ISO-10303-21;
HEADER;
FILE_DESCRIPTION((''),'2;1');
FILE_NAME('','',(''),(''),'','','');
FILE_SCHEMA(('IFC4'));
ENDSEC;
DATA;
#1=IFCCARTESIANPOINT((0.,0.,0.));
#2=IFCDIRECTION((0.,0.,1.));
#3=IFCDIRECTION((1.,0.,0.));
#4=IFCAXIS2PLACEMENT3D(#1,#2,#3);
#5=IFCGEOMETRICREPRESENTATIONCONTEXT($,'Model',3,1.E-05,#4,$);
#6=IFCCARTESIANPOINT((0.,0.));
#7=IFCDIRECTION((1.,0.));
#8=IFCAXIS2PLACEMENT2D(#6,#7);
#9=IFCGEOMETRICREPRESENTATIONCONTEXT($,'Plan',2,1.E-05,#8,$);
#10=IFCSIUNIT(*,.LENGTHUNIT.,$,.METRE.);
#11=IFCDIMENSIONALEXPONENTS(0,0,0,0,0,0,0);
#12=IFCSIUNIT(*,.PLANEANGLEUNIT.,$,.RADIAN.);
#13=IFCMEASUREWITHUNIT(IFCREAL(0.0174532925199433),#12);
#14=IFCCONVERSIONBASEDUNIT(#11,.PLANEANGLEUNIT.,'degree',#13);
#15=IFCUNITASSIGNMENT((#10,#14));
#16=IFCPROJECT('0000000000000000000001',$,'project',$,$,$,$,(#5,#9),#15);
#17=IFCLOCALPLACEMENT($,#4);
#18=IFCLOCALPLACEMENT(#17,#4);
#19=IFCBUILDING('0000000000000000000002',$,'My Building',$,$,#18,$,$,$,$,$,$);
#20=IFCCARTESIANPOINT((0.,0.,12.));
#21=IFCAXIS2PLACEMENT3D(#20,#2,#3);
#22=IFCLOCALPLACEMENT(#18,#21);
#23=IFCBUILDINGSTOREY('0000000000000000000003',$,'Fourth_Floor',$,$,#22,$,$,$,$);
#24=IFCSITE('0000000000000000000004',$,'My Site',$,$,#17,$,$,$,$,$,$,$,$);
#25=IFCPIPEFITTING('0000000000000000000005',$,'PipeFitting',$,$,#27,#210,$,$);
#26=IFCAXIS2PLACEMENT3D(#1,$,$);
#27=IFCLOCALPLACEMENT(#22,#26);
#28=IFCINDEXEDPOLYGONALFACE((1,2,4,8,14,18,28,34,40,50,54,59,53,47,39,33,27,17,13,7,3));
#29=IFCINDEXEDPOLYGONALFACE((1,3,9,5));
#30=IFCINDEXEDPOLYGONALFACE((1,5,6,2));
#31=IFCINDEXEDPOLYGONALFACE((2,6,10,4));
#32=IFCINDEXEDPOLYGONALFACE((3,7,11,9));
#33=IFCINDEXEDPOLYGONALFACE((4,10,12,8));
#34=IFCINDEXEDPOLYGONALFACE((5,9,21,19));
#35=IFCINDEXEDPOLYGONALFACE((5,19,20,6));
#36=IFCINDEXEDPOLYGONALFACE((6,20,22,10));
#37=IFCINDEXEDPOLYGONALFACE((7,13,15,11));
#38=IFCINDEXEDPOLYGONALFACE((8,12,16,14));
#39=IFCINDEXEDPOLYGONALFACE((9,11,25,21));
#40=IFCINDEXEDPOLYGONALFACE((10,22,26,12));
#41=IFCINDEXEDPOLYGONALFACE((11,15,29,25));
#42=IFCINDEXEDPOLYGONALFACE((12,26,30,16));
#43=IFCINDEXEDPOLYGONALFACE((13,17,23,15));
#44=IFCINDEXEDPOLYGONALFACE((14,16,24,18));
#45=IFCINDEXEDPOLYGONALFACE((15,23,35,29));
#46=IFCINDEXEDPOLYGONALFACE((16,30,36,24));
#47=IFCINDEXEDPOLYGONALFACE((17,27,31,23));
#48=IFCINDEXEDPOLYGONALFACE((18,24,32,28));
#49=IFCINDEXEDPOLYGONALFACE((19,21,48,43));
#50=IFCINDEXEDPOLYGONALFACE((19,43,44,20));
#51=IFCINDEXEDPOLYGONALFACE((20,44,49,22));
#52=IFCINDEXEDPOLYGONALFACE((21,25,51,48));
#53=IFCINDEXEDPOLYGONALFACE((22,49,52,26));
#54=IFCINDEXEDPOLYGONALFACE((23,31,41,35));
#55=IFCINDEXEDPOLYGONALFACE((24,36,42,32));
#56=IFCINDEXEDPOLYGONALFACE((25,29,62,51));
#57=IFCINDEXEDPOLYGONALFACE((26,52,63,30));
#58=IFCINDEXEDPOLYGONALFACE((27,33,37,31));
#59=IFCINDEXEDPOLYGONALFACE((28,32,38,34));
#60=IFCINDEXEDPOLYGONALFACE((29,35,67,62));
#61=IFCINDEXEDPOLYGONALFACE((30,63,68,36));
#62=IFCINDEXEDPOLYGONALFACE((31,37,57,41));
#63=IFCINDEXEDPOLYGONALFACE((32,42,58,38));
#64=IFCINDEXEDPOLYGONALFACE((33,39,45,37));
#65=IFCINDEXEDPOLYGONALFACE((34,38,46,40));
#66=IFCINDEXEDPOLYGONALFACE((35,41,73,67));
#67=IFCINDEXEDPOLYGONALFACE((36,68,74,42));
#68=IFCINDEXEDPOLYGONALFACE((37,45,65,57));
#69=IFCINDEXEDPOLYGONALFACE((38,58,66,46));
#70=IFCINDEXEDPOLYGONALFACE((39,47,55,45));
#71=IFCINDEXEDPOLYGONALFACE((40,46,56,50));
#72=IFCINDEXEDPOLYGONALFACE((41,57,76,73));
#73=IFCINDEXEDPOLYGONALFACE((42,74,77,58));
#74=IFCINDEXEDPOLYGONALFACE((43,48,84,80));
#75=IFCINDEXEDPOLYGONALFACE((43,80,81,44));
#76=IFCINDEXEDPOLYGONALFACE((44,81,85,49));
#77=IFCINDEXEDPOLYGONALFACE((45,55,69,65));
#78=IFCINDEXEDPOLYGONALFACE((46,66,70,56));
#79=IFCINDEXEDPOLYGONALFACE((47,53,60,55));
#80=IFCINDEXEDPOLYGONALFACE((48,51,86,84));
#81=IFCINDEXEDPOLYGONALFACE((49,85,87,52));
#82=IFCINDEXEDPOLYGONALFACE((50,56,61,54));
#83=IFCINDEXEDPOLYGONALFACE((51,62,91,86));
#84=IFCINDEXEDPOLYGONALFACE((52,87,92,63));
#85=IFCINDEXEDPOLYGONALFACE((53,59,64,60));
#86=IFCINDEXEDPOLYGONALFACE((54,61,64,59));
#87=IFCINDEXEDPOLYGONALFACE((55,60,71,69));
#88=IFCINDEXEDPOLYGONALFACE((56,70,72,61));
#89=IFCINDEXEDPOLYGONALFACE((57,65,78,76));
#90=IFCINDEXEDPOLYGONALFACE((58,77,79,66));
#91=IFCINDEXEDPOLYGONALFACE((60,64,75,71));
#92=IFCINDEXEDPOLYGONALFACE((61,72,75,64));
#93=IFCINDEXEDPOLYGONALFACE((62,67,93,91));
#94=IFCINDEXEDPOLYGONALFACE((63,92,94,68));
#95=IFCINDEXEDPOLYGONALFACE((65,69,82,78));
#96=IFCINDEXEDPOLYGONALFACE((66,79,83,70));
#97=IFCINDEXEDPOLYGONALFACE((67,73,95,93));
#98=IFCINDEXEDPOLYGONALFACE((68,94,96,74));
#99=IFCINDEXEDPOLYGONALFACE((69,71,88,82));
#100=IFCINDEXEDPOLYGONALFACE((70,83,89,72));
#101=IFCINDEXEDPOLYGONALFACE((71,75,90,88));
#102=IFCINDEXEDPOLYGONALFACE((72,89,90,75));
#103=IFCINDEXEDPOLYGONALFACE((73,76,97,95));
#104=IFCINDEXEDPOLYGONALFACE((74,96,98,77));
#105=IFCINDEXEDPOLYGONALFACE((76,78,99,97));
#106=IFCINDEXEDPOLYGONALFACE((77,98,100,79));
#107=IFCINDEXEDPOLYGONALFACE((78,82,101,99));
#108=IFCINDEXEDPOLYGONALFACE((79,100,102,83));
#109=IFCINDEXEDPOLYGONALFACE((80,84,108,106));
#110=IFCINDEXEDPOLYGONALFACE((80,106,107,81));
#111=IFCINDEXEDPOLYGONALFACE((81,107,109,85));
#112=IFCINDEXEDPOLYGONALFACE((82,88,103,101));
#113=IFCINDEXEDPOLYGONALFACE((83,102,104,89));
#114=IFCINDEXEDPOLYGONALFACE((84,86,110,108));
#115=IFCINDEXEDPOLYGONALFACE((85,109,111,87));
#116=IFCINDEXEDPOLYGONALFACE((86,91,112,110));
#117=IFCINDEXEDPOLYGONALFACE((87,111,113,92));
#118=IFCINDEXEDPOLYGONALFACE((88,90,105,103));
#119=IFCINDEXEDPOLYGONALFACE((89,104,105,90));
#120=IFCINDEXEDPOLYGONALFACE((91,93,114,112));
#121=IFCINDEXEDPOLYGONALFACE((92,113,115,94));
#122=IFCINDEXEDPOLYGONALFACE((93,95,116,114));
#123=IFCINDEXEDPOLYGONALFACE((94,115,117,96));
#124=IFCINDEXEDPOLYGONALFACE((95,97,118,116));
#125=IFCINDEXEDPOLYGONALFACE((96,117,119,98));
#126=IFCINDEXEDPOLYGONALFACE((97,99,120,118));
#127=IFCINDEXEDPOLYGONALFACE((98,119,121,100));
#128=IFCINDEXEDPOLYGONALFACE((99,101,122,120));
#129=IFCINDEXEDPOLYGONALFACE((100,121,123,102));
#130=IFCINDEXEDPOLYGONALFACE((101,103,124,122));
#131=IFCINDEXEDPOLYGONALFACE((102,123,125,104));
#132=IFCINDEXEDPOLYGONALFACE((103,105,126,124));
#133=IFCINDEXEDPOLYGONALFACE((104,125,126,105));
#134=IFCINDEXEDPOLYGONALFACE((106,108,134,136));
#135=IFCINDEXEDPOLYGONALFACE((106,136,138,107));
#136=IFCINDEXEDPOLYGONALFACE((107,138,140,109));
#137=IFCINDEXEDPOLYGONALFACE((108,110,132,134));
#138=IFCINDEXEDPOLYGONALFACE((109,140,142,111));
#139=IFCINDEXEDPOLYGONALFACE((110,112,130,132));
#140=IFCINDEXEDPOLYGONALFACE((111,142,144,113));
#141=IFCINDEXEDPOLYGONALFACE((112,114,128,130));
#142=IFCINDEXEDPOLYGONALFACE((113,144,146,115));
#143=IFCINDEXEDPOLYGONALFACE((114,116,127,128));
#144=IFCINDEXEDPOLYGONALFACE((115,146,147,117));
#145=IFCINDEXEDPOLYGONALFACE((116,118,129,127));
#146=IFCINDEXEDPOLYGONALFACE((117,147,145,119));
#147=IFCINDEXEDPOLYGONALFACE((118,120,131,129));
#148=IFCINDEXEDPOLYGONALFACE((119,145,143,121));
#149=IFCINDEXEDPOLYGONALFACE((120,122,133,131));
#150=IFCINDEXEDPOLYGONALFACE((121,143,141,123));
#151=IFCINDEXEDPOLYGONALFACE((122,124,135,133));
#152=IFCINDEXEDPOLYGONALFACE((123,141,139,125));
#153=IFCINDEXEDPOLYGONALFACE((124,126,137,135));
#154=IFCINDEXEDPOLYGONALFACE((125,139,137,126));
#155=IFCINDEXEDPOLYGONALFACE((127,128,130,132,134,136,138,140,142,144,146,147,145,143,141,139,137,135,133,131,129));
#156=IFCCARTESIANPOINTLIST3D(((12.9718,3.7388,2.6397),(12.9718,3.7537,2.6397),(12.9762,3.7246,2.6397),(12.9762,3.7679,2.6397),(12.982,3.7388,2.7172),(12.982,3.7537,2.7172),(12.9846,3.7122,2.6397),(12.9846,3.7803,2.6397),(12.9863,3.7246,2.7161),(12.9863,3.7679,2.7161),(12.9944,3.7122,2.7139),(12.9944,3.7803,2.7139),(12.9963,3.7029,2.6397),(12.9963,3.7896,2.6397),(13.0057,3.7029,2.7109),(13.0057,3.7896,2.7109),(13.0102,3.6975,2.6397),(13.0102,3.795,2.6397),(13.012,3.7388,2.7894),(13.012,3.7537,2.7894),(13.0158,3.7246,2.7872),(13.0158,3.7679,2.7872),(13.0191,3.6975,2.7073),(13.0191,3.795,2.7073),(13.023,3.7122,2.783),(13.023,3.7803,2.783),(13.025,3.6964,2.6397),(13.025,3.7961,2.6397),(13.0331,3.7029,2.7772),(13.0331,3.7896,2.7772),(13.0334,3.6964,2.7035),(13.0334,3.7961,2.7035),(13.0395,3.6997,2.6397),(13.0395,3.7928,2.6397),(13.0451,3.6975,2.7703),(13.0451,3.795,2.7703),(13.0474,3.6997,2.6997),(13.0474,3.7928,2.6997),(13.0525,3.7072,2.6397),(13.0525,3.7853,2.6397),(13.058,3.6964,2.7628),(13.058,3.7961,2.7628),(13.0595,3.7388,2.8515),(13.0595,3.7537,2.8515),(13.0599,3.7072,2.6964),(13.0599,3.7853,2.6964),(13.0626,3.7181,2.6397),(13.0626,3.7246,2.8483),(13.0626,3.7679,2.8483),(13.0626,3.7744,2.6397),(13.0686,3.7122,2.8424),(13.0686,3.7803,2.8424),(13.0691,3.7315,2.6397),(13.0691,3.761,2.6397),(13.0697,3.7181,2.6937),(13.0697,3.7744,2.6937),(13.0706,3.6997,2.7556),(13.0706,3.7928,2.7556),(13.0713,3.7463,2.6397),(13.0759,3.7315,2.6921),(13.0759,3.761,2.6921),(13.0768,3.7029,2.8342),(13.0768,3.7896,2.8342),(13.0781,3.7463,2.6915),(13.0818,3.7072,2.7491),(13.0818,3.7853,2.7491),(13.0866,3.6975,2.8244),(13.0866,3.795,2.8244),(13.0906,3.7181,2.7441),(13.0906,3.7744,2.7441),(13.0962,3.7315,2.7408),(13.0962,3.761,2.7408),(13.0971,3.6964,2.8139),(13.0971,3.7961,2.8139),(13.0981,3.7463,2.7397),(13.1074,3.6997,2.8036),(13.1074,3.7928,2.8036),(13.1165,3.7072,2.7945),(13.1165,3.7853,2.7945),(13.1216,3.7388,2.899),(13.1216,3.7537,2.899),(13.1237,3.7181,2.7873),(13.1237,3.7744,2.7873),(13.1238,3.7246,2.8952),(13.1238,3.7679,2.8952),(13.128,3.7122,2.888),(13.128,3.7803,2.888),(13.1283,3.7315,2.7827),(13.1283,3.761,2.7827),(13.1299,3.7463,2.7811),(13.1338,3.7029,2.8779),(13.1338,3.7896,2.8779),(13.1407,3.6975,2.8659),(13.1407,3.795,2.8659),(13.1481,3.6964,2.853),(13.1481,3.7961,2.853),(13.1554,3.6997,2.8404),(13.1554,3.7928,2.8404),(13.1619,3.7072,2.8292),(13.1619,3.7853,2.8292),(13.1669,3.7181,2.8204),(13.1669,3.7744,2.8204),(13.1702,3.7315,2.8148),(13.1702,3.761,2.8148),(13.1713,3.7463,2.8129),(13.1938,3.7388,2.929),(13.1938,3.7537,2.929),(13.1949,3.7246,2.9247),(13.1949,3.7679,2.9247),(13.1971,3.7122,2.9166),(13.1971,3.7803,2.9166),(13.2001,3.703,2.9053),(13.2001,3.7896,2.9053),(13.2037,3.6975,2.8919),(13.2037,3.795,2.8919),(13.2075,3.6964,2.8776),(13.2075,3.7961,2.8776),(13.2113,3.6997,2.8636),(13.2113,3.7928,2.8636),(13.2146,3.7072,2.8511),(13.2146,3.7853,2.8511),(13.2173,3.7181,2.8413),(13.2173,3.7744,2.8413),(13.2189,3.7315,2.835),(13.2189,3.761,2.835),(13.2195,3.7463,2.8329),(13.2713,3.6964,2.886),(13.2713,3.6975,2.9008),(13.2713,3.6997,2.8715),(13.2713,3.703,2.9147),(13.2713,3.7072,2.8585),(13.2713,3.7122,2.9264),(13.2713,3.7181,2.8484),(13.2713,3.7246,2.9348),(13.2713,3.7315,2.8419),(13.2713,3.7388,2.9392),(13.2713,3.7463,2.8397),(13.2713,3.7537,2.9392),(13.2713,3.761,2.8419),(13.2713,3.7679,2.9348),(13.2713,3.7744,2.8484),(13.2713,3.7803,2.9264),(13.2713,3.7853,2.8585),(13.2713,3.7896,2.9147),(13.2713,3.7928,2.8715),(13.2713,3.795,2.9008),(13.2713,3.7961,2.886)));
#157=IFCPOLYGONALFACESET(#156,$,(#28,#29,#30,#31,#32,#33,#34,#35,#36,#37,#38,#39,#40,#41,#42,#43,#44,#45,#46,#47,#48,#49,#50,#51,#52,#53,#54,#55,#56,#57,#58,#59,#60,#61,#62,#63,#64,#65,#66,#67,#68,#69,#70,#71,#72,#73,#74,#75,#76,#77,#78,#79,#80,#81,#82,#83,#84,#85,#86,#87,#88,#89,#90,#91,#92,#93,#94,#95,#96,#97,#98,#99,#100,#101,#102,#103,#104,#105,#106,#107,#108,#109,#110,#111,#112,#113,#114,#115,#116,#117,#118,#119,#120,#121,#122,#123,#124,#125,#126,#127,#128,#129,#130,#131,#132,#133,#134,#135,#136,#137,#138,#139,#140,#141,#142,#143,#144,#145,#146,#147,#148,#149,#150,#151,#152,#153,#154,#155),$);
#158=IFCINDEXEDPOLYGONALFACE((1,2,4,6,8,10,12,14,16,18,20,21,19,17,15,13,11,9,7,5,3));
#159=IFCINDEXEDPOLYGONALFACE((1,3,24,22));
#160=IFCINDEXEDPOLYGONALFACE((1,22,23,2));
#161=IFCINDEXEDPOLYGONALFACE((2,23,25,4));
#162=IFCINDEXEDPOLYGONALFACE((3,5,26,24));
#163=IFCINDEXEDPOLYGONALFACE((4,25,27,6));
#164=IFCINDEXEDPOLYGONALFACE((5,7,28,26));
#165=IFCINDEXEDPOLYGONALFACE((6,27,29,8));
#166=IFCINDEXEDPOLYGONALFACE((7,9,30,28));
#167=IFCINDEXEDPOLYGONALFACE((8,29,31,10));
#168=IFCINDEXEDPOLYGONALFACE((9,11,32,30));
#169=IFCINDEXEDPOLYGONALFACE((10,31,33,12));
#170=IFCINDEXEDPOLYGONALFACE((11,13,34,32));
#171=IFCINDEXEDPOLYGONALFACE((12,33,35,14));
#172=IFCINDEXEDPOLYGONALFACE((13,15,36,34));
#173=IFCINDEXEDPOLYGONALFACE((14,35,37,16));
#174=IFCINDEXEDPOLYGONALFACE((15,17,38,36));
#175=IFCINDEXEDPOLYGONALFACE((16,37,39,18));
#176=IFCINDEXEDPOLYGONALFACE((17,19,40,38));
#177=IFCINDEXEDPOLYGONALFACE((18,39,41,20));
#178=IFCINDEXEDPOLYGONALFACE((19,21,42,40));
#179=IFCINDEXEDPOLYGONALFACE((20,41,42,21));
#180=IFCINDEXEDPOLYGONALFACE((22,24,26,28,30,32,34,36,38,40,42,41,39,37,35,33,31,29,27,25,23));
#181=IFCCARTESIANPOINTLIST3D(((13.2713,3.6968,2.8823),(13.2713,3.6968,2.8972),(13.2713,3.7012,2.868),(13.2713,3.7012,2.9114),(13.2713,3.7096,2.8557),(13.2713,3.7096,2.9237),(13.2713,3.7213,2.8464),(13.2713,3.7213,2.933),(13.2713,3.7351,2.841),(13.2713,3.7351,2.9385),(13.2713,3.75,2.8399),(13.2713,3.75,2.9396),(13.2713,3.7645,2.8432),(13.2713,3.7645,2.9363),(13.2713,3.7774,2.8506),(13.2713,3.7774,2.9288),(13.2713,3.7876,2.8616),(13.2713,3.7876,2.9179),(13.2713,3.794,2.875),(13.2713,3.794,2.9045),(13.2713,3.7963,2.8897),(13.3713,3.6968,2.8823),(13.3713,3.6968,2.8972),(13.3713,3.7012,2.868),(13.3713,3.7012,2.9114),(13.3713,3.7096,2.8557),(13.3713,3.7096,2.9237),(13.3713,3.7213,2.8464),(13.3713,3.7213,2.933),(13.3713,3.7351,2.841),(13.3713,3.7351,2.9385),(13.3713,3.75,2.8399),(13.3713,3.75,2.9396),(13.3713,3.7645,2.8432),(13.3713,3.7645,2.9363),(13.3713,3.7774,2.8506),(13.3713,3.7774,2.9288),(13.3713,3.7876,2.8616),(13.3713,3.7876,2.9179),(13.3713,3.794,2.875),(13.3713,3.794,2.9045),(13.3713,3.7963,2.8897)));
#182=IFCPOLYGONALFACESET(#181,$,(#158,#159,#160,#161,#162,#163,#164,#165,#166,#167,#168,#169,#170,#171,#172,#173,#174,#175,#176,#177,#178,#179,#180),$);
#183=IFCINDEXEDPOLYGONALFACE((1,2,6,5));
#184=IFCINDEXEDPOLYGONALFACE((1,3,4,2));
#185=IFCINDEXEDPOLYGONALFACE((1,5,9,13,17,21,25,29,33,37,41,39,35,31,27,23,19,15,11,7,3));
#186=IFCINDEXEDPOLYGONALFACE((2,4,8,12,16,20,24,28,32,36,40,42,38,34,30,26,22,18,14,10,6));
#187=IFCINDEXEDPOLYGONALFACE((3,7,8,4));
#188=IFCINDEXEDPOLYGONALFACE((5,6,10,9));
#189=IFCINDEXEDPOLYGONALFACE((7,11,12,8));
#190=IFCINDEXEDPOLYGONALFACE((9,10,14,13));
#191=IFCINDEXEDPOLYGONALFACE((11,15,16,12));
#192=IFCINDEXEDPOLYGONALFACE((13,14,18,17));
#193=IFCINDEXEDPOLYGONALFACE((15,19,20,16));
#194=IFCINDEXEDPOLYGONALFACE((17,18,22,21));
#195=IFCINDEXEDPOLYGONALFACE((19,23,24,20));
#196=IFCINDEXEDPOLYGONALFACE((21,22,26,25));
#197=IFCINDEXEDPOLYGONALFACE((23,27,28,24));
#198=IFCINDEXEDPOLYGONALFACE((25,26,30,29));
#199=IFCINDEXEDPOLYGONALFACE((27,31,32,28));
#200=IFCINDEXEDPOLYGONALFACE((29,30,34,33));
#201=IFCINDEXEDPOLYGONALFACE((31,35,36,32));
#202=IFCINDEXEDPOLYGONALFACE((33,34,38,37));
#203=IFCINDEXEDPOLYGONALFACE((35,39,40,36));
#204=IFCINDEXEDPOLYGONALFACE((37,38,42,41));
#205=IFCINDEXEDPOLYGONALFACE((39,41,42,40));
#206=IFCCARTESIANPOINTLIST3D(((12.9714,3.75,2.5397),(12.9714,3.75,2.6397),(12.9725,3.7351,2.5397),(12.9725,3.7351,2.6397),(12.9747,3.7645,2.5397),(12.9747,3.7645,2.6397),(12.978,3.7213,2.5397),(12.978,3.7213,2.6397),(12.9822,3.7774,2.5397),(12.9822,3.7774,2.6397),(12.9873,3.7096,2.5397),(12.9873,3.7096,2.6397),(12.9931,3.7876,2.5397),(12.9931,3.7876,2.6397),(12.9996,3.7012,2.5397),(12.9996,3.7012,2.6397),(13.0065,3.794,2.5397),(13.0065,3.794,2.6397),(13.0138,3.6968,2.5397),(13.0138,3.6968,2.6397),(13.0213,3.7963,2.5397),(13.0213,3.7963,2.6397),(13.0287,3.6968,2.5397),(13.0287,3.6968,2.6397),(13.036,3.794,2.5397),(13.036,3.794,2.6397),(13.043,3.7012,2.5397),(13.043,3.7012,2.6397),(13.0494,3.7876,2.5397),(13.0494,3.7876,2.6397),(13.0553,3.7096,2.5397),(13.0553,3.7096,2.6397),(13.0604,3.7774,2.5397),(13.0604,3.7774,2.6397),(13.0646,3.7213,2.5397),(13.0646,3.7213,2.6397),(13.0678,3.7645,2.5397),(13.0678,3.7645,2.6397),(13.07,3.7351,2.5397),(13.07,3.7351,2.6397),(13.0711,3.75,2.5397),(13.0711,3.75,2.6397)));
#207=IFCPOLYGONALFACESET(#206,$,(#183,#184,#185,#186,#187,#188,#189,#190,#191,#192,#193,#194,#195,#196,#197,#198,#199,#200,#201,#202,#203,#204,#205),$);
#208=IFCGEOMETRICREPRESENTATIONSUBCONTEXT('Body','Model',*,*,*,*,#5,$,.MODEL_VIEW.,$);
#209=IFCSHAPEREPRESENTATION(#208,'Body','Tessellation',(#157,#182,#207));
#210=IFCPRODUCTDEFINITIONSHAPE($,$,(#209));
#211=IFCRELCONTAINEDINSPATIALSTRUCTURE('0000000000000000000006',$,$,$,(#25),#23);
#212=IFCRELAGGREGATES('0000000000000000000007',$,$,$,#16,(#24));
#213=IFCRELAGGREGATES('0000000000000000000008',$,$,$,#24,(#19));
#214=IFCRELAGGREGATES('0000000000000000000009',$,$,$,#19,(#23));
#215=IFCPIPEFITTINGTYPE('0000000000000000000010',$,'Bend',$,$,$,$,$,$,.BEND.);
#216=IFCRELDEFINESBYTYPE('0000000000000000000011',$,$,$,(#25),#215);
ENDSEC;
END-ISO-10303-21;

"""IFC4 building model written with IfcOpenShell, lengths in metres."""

from ifc_helpers import new_model, entity, si_unit, converted_unit, frame, origin_with_axes, origin_2d_with_axis, place, context, subcontext, project, spatial, circle, extrude, source, transform, mapped, type_object, type_shapes, element, save


model = new_model("IFC4")

# Units and contexts
model_context = context("Model", 3, precision=1e-05, world=origin_with_axes())
plan_context = context("Plan", 2, precision=1e-05, world=origin_2d_with_axis())
body_context_1 = subcontext(model_context, "Body", "Model", "MODEL_VIEW")
ifc_project = project(units=[si_unit("LENGTHUNIT", "METRE"), converted_unit("PLANEANGLEUNIT", "degree", entity("IfcReal", 0.0174532925199433), si_unit("PLANEANGLEUNIT", "RADIAN"), dimensions=[0, 0, 0, 0, 0, 0, 0])], contexts=[model_context, plan_context])

# Site, building, storey
site_placement = place(None, origin_with_axes())
site = spatial("IfcSite", under=ifc_project, at=site_placement, Name="My Site")
building_placement = place(site_placement, origin_with_axes())
building = spatial("IfcBuilding", under=site, at=building_placement, Name="My Building")
storey_placement = place(building_placement, frame((0.0, 0.0, 12.0), z_axis=(0.0, 0.0, 1.0), x_axis=(1.0, 0.0, 0.0)))
storey = spatial("IfcBuildingStorey", under=building, at=storey_placement, Name="Fourth_Floor")

# Pipe fitting
pipe_fitting_type = type_object("IfcPipeFittingType", Name="Bend", PredefinedType="BEND")
shared_shape_1 = source(origin_with_axes(), body_context_1, "Body", "SolidModel", [
    entity("IfcSweptDiskSolid", entity("IfcIndexedPolyCurve", entity("IfcCartesianPointList3D", [[0.0, 0.0, -0.1], [0.0, -0.0732, -0.2768], [0.0, -0.25, -0.35]]), [entity("IfcArcIndex", [1, 2, 3])]), 0.05),
    extrude(circle(Radius=0.05), origin_with_axes(), (0.0, 0.0, -1.0), 0.1),
    extrude(circle(Radius=0.05), frame((0.0, -0.25, -0.35), z_axis=(0.0, -1.0, 0.0), x_axis=(1.0, 0.0, 0.0)), (0.0, 0.0, 1.0), 0.1),
])
type_shapes(pipe_fitting_type, [shared_shape_1])
for number, where, z_axis, x_axis, name in (
    (1, (13.3713, 3.7463, 2.8897), (1.0, 0.0, 0.0), (0.0, 1.0, 0.0), "PipeFitting"),
):
    element("IfcPipeFitting", number, at=place(storey_placement, frame(where, z_axis=z_axis, x_axis=x_axis)), inside=storey, type_object=pipe_fitting_type, Name=name, context=body_context_1, shape_type="MappedRepresentation", body=[
        mapped(shared_shape_1, transform((0.0, 0.0, 0.0), x_axis=(1.0, 0.0, 0.0), y_axis=(0.0, 1.0, 0.0), z_axis=(0.0, 0.0, 1.0), scale=1.0)),
    ])

save(model, "model.ifc")
